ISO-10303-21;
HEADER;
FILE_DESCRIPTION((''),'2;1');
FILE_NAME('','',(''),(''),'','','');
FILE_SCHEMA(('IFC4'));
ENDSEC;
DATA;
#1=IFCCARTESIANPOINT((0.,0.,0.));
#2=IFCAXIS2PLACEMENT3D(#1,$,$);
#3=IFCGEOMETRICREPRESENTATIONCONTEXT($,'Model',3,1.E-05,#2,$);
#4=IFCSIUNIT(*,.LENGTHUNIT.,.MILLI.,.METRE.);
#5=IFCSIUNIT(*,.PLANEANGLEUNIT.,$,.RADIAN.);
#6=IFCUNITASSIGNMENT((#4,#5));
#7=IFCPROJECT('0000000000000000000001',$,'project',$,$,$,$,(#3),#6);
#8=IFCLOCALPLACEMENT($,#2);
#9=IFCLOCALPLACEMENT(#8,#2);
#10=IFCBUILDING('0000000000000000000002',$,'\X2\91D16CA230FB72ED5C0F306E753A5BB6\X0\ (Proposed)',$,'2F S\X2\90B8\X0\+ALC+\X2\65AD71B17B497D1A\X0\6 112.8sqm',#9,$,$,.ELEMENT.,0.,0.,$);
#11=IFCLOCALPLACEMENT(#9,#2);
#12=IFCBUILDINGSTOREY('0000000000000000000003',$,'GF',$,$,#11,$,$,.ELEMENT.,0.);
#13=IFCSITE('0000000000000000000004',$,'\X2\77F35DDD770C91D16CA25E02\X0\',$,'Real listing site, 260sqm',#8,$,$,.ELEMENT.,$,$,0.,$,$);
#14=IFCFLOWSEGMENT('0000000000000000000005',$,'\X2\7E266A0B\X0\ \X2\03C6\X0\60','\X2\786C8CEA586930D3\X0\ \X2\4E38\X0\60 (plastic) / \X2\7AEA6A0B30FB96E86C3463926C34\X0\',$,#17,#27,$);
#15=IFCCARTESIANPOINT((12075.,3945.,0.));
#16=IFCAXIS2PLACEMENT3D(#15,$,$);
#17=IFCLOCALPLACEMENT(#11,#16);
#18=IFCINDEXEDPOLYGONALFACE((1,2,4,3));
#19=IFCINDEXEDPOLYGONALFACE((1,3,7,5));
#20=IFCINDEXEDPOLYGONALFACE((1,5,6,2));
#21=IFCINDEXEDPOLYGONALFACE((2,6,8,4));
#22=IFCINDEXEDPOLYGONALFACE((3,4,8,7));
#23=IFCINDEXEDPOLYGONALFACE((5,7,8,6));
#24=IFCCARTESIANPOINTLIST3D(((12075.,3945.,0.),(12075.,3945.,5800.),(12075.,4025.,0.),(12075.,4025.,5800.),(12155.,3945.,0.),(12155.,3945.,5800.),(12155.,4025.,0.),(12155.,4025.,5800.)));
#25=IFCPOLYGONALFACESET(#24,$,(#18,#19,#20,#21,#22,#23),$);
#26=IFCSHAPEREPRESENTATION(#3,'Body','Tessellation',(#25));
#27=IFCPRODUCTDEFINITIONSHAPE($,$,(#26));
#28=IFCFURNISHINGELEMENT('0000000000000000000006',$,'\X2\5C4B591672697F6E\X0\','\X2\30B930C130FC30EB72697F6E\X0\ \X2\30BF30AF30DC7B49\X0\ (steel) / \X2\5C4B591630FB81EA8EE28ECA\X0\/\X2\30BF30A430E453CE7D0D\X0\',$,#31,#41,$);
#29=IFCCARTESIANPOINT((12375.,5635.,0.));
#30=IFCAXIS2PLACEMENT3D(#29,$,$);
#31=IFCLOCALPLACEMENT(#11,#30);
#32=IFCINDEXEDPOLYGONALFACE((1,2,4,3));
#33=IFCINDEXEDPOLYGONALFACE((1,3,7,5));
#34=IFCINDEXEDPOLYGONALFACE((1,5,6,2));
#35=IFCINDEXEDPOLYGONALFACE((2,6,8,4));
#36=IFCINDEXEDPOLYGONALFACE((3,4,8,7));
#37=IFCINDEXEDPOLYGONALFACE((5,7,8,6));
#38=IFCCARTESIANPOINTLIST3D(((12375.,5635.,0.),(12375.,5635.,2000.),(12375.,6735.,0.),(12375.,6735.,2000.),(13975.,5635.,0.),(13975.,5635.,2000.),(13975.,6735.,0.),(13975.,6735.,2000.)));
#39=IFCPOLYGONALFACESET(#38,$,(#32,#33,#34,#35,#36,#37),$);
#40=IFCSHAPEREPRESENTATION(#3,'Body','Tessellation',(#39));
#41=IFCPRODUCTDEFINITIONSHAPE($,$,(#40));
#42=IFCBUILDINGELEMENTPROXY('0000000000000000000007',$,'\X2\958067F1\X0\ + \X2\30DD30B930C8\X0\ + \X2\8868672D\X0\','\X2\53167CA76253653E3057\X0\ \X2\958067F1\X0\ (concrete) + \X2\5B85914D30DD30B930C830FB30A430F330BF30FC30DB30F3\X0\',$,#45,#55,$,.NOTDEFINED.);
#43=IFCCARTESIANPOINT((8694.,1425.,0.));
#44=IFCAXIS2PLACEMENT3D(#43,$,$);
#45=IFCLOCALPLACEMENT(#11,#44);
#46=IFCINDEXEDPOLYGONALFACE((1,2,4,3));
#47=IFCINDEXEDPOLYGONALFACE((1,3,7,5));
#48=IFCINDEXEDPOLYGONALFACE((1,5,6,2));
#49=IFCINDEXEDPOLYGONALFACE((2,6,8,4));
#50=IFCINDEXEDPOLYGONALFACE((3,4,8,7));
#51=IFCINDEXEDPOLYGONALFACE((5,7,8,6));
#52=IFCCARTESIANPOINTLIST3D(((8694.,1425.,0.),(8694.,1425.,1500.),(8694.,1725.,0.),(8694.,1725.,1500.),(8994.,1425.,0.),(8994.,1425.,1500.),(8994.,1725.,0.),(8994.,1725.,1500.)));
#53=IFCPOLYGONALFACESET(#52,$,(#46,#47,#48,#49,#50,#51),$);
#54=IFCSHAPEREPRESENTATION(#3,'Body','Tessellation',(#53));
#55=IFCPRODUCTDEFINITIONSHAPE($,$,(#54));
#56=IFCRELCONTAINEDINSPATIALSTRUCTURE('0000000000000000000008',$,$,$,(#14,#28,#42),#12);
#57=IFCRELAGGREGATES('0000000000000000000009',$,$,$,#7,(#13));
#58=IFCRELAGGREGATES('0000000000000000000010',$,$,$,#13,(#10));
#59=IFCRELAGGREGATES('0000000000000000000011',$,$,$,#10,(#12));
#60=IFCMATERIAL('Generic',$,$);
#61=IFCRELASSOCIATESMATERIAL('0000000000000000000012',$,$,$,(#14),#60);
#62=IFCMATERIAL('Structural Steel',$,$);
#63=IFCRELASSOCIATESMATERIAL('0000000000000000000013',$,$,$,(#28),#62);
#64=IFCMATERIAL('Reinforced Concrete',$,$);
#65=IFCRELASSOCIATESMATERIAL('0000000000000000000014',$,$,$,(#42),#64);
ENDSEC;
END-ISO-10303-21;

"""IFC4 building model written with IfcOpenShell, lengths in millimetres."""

from ifc_helpers import new_model, si_unit, frame, frame_2d, origin, place, context, project, spatial, rectangle, extrude, material, element, save


model = new_model("IFC4")

# Units and contexts
model_context = context("Model", 3, precision=1e-05, world=origin())
ifc_project = project(units=[si_unit("LENGTHUNIT", "METRE", prefix="MILLI"), si_unit("PLANEANGLEUNIT", "RADIAN")], contexts=[model_context])

# Site, building, storey
site_placement = place(None, origin())
site = spatial("IfcSite", under=ifc_project, at=site_placement, Name="石川県金沢市", ObjectType="Real listing site, 260sqm", CompositionType="ELEMENT", RefElevation=0.0)
building_placement = place(site_placement, origin())
building = spatial("IfcBuilding", under=site, at=building_placement, Name="金沢・狭小の町家 (Proposed)", ObjectType="2F S邸+ALC+断熱等級6 112.8sqm", CompositionType="ELEMENT", ElevationOfRefHeight=0.0, ElevationOfTerrain=0.0)
storey_placement = place(building_placement, origin())
storey = spatial("IfcBuildingStorey", under=building, at=storey_placement, Name="GF", CompositionType="ELEMENT", Elevation=0.0)

# Shared definitions
ifc_material_1 = material(Name="Reinforced Concrete")

# Flow segment
ifc_material_2 = material(Name="Generic")
flow_segment_placement = place(storey_placement, frame((12075.0, 3945.0, 0.0)))
element("IfcFlowSegment", 1, at=flow_segment_placement, inside=storey, material=ifc_material_2, Name="縦樋 φ60", Description="硬質塩ビ 丸60 (plastic) / 竪樋・雨水排水", context=model_context, shape_type="SweptSolid", body=[
    extrude(rectangle(XDim=80.0, YDim=80.0, at=frame_2d((40.0, 40.0))), frame((12075.0, 3945.0, 0.0)), (0.0, 0.0, 1.0), 5800.0),
])

# Furnishing element
ifc_material_3 = material(Name="Structural Steel")
furnishing_placement = place(storey_placement, frame((12375.0, 5635.0, 0.0)))
element("IfcFurnishingElement", 2, at=furnishing_placement, inside=storey, material=ifc_material_3, Name="屋外物置", Description="スチール物置 タクボ等 (steel) / 屋外・自転車/タイヤ収納", context=model_context, shape_type="SweptSolid", body=[
    extrude(rectangle(XDim=1600.0, YDim=1100.0, at=frame_2d((800.0, 550.0))), frame((12375.0, 5635.0, 0.0)), (0.0, 0.0, 1.0), 2000.0),
])

# Building element proxy
proxy_placement = place(storey_placement, frame((8694.0, 1425.0, 0.0)))
element("IfcBuildingElementProxy", 3, at=proxy_placement, inside=storey, material=ifc_material_1, Name="門柱 + ポスト + 表札", Description="化粧打放し 門柱 (concrete) + 宅配ポスト・インターホン", PredefinedType="NOTDEFINED", context=model_context, shape_type="SweptSolid", body=[
    extrude(rectangle(XDim=300.0, YDim=300.0, at=frame_2d((150.0, 150.0))), frame((8694.0, 1425.0, 0.0)), (0.0, 0.0, 1.0), 1500.0),
])

save(model, "model.ifc")
